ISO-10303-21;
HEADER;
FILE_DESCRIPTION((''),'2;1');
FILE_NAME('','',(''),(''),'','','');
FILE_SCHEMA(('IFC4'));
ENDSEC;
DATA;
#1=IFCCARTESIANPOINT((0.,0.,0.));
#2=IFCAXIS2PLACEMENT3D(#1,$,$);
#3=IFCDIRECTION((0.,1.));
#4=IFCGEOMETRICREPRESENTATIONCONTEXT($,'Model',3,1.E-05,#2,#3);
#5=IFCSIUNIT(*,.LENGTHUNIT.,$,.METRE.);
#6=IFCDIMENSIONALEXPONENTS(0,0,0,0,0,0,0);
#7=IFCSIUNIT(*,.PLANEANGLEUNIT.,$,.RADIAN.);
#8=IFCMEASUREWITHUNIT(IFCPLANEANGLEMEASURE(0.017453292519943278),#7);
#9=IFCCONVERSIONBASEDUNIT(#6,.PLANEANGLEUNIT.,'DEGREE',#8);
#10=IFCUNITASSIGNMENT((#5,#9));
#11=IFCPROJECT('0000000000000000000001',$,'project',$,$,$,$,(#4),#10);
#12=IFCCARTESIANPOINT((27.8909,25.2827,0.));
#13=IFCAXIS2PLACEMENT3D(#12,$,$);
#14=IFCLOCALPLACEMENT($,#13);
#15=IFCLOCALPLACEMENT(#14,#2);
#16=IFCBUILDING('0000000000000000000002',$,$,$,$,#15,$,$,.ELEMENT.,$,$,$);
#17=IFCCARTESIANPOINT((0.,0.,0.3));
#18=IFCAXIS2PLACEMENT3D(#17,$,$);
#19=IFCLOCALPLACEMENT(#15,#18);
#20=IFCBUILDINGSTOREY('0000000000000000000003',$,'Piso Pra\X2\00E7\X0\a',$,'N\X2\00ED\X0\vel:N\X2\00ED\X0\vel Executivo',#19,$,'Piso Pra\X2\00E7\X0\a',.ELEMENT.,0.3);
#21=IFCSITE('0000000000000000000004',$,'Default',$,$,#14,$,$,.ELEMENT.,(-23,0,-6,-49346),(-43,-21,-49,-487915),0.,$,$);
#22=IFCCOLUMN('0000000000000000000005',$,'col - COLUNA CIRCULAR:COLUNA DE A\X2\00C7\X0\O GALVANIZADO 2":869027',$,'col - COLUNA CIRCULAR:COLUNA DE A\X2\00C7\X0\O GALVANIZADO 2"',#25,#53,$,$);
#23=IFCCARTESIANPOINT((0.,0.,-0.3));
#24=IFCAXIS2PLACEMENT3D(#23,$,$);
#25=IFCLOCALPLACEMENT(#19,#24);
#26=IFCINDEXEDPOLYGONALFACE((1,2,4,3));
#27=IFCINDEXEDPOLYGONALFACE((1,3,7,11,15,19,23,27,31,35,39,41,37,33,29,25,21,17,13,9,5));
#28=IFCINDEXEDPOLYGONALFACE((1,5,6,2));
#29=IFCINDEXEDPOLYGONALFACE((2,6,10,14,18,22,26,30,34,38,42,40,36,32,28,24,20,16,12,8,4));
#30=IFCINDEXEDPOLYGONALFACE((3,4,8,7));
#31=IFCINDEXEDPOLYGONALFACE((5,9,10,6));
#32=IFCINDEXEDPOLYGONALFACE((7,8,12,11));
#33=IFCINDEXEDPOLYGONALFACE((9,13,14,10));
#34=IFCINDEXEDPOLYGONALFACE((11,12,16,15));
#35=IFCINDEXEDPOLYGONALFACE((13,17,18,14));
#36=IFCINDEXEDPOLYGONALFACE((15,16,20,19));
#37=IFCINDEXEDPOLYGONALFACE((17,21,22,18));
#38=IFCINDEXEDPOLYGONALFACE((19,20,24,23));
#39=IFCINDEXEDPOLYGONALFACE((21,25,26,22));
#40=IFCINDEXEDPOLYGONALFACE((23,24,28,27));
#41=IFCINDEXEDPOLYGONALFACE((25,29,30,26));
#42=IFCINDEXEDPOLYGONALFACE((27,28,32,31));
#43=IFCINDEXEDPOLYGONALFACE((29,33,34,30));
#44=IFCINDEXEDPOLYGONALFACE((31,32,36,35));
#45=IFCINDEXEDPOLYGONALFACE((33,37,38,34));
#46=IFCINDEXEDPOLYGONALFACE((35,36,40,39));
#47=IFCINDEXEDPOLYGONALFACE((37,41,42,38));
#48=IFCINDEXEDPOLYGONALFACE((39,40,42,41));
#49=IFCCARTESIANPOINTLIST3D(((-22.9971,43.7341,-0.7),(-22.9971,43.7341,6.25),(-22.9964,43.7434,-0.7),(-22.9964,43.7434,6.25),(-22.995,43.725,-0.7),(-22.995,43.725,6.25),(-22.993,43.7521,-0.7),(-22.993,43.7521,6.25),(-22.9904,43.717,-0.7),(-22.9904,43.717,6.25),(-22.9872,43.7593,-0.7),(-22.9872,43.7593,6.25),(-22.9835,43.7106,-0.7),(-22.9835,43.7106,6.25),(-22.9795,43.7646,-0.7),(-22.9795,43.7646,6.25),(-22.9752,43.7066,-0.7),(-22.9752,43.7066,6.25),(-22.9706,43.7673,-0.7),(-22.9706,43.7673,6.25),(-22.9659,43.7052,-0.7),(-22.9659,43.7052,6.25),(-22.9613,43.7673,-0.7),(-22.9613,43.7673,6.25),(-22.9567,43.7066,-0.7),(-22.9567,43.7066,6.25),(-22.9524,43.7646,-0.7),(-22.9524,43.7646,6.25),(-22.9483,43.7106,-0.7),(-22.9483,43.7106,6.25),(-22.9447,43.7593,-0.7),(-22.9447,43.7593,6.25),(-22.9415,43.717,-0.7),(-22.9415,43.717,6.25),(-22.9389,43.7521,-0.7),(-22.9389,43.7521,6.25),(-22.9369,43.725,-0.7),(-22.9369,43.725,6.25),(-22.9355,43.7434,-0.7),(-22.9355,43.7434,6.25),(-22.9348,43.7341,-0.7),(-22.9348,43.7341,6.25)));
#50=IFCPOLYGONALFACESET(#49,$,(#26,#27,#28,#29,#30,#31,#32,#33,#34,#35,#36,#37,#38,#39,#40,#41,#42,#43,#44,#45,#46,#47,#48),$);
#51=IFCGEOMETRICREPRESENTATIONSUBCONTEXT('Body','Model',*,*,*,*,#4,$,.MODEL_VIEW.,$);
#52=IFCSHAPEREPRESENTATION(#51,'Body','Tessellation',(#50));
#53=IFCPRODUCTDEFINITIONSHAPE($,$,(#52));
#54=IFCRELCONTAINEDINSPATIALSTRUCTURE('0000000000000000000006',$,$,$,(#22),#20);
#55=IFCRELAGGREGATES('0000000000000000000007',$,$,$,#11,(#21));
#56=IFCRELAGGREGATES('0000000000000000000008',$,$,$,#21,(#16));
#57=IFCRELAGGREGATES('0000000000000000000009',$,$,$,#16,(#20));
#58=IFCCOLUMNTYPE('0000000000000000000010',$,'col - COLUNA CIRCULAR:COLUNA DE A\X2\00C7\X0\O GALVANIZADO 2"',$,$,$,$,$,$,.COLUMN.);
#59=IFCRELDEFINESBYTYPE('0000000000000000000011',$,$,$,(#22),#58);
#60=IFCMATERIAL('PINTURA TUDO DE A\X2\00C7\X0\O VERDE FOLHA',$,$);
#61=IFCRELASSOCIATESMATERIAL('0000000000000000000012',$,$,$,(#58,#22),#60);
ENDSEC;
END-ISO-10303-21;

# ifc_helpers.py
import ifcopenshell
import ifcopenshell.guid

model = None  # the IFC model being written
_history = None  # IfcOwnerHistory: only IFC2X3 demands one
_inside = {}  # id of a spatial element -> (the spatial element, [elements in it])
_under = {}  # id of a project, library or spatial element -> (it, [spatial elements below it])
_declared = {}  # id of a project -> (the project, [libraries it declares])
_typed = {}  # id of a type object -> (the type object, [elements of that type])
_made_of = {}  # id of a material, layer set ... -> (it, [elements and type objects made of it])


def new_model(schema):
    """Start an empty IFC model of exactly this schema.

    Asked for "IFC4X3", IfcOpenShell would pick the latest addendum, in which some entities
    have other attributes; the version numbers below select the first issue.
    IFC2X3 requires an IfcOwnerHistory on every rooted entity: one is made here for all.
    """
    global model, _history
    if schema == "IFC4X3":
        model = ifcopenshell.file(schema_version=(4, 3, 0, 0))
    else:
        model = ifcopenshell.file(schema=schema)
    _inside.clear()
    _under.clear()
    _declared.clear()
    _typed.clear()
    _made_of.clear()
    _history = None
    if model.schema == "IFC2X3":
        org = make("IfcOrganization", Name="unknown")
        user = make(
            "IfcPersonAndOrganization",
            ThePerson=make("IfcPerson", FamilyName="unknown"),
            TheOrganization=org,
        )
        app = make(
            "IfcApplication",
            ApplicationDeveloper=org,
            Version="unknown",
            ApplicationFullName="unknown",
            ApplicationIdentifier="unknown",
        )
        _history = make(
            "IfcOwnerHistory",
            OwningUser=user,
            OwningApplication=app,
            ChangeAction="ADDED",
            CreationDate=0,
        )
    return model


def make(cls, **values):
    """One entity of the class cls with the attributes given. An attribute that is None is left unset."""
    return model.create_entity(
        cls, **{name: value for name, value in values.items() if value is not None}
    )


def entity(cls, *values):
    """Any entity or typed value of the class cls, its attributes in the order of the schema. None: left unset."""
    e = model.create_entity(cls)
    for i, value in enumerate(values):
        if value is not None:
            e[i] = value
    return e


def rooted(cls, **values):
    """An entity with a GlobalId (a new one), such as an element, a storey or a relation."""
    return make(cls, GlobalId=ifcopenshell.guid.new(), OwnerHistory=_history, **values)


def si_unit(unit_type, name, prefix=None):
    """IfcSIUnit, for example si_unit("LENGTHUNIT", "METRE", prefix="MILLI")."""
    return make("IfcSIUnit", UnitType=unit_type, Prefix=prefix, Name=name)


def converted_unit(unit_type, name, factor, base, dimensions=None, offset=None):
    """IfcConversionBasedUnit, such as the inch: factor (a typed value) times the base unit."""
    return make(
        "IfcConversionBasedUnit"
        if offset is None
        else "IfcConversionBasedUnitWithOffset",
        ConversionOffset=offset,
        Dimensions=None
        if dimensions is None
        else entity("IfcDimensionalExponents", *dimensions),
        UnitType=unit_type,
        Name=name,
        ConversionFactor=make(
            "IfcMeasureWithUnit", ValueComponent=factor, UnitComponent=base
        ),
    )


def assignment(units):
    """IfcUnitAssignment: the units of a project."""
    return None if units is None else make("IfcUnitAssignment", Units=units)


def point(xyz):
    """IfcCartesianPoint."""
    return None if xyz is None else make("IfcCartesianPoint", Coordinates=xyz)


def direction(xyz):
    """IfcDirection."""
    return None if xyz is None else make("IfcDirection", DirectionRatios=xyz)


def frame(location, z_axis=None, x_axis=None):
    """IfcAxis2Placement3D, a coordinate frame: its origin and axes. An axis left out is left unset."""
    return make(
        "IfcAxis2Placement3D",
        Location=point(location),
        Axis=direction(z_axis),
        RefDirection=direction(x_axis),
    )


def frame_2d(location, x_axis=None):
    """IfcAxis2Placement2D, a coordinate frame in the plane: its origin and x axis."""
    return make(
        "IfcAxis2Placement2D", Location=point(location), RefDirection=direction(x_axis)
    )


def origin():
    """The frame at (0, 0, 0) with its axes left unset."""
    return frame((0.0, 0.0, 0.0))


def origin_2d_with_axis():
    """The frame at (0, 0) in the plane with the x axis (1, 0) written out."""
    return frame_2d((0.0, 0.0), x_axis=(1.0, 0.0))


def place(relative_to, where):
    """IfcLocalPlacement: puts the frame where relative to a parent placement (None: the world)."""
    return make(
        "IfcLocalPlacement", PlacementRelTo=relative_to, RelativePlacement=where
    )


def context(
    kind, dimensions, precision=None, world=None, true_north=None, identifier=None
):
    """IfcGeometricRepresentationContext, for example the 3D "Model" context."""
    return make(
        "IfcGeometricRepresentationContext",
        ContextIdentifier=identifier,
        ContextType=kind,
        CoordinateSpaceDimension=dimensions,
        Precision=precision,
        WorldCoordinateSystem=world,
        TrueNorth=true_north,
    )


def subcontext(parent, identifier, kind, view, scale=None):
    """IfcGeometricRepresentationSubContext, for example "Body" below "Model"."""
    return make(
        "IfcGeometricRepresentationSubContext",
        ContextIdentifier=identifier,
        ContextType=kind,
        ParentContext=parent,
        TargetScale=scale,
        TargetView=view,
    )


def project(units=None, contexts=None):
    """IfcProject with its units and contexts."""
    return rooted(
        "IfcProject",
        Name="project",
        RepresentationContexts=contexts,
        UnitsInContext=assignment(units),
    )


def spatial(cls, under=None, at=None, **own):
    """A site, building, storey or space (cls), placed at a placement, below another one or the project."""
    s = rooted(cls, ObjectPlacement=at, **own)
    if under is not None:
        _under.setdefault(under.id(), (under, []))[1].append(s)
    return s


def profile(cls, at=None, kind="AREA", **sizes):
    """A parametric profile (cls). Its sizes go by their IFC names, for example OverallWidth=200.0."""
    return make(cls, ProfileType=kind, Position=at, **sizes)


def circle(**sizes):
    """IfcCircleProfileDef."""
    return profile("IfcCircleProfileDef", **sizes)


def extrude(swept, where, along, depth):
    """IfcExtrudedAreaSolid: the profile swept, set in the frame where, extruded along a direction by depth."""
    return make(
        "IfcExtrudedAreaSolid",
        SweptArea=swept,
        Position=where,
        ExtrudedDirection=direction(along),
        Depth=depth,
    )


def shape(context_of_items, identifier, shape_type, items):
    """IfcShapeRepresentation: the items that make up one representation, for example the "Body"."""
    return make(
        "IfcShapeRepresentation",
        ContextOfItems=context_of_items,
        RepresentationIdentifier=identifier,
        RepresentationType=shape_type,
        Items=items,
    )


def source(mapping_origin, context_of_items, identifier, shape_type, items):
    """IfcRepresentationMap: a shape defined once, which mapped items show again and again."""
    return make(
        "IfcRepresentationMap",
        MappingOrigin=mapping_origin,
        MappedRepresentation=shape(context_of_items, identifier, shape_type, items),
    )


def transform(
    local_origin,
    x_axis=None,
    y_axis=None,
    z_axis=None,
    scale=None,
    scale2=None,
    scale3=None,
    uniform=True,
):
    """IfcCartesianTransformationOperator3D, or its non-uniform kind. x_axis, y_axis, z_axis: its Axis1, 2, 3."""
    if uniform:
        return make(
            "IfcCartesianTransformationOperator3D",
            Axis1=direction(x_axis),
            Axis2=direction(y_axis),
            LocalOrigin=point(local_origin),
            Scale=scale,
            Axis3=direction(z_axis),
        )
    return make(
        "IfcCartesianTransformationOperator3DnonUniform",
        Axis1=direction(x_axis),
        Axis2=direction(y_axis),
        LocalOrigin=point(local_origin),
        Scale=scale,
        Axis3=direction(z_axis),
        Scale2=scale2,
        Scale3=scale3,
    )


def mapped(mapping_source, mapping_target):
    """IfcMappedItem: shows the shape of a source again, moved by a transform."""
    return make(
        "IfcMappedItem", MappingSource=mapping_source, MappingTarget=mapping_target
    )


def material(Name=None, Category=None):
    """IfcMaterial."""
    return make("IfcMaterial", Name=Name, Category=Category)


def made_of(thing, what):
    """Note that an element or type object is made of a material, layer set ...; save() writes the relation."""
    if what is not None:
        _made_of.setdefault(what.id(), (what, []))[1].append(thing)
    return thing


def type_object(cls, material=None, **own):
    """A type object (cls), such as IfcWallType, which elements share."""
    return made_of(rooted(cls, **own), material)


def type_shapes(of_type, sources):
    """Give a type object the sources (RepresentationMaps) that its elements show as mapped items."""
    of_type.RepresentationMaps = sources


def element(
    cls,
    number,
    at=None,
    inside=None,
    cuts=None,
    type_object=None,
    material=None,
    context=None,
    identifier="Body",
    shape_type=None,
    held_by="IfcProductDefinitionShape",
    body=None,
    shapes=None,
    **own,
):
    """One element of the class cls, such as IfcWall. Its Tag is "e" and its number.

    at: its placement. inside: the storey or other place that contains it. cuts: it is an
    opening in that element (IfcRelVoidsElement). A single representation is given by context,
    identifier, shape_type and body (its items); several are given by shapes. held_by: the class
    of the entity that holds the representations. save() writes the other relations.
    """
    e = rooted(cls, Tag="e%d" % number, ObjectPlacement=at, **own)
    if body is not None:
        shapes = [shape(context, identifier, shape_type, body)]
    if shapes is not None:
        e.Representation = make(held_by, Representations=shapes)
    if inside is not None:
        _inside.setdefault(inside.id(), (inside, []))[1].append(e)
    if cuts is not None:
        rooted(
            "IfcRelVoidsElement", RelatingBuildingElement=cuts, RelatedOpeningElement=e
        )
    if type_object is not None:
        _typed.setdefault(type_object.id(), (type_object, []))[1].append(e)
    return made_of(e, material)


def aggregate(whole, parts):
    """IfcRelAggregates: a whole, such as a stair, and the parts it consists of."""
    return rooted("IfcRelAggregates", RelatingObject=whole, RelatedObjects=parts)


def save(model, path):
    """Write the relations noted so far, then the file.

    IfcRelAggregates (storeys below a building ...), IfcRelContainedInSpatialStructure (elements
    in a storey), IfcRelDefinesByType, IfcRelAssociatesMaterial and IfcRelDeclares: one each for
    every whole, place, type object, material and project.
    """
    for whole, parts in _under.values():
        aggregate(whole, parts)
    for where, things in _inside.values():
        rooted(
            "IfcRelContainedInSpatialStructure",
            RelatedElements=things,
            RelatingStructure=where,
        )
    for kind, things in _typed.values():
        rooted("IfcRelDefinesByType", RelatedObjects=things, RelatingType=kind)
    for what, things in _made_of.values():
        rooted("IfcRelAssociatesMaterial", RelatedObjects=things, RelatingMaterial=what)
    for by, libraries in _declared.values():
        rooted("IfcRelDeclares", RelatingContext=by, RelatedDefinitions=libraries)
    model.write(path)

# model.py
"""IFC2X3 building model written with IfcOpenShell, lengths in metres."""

from ifc_helpers import new_model, entity, si_unit, converted_unit, direction, frame, origin, origin_2d_with_axis, place, context, subcontext, project, spatial, circle, extrude, source, transform, mapped, material, type_object, type_shapes, element, save


model = new_model("IFC2X3")

# Units and contexts
model_context = context("Model", 3, precision=1e-05, world=origin(), true_north=direction((0.0, 1.0)))
body_context = subcontext(model_context, "Body", "Model", "MODEL_VIEW")
ifc_project = project(units=[si_unit("LENGTHUNIT", "METRE"), converted_unit("PLANEANGLEUNIT", "DEGREE", entity("IfcPlaneAngleMeasure", 0.017453292519943278), si_unit("PLANEANGLEUNIT", "RADIAN"), dimensions=[0, 0, 0, 0, 0, 0, 0])], contexts=[model_context])

# Site, building, storey
site_placement = place(None, frame((27.8909, 25.2827, 0.0)))
site = spatial("IfcSite", under=ifc_project, at=site_placement, Name="Default", CompositionType="ELEMENT", RefLatitude=(-23, 0, -6, -49346), RefLongitude=(-43, -21, -49, -487915), RefElevation=0.0)
building_placement = place(site_placement, origin())
building = spatial("IfcBuilding", under=site, at=building_placement, CompositionType="ELEMENT")
storey_placement = place(building_placement, frame((0.0, 0.0, 0.3)))
storey = spatial("IfcBuildingStorey", under=building, at=storey_placement, Name="Piso Praça", ObjectType="Nível:Nível Executivo", LongName="Piso Praça", CompositionType="ELEMENT", Elevation=0.3)

# Column
ifc_material = material(Name="PINTURA TUDO DE AÇO VERDE FOLHA")
column_type_1 = type_object("IfcColumnType", Name="col - COLUNA CIRCULAR:COLUNA DE AÇO GALVANIZADO 2\"", PredefinedType="COLUMN", material=ifc_material)
shared_shape_1 = source(origin(), body_context, "Body", "SweptSolid", [
    extrude(circle(Radius=0.0312, at=origin_2d_with_axis()), frame((-22.9659, 43.7364, -0.7), z_axis=(0.0, 0.0, 1.0), x_axis=(0.0, -1.0, 0.0)), (0.0, 0.0, 1.0), 6.95),
])
type_shapes(column_type_1, [shared_shape_1])
column_1_placement = place(storey_placement, frame((0.0, 0.0, -0.3)))
element("IfcColumn", 1, at=column_1_placement, inside=storey, type_object=column_type_1, material=ifc_material, Name="col - COLUNA CIRCULAR:COLUNA DE AÇO GALVANIZADO 2\":869027", ObjectType="col - COLUNA CIRCULAR:COLUNA DE AÇO GALVANIZADO 2\"", context=body_context, shape_type="MappedRepresentation", body=[
    mapped(shared_shape_1, transform((0.0, 0.0, 0.0), scale=1.0)),
])

save(model, "model.ifc")
